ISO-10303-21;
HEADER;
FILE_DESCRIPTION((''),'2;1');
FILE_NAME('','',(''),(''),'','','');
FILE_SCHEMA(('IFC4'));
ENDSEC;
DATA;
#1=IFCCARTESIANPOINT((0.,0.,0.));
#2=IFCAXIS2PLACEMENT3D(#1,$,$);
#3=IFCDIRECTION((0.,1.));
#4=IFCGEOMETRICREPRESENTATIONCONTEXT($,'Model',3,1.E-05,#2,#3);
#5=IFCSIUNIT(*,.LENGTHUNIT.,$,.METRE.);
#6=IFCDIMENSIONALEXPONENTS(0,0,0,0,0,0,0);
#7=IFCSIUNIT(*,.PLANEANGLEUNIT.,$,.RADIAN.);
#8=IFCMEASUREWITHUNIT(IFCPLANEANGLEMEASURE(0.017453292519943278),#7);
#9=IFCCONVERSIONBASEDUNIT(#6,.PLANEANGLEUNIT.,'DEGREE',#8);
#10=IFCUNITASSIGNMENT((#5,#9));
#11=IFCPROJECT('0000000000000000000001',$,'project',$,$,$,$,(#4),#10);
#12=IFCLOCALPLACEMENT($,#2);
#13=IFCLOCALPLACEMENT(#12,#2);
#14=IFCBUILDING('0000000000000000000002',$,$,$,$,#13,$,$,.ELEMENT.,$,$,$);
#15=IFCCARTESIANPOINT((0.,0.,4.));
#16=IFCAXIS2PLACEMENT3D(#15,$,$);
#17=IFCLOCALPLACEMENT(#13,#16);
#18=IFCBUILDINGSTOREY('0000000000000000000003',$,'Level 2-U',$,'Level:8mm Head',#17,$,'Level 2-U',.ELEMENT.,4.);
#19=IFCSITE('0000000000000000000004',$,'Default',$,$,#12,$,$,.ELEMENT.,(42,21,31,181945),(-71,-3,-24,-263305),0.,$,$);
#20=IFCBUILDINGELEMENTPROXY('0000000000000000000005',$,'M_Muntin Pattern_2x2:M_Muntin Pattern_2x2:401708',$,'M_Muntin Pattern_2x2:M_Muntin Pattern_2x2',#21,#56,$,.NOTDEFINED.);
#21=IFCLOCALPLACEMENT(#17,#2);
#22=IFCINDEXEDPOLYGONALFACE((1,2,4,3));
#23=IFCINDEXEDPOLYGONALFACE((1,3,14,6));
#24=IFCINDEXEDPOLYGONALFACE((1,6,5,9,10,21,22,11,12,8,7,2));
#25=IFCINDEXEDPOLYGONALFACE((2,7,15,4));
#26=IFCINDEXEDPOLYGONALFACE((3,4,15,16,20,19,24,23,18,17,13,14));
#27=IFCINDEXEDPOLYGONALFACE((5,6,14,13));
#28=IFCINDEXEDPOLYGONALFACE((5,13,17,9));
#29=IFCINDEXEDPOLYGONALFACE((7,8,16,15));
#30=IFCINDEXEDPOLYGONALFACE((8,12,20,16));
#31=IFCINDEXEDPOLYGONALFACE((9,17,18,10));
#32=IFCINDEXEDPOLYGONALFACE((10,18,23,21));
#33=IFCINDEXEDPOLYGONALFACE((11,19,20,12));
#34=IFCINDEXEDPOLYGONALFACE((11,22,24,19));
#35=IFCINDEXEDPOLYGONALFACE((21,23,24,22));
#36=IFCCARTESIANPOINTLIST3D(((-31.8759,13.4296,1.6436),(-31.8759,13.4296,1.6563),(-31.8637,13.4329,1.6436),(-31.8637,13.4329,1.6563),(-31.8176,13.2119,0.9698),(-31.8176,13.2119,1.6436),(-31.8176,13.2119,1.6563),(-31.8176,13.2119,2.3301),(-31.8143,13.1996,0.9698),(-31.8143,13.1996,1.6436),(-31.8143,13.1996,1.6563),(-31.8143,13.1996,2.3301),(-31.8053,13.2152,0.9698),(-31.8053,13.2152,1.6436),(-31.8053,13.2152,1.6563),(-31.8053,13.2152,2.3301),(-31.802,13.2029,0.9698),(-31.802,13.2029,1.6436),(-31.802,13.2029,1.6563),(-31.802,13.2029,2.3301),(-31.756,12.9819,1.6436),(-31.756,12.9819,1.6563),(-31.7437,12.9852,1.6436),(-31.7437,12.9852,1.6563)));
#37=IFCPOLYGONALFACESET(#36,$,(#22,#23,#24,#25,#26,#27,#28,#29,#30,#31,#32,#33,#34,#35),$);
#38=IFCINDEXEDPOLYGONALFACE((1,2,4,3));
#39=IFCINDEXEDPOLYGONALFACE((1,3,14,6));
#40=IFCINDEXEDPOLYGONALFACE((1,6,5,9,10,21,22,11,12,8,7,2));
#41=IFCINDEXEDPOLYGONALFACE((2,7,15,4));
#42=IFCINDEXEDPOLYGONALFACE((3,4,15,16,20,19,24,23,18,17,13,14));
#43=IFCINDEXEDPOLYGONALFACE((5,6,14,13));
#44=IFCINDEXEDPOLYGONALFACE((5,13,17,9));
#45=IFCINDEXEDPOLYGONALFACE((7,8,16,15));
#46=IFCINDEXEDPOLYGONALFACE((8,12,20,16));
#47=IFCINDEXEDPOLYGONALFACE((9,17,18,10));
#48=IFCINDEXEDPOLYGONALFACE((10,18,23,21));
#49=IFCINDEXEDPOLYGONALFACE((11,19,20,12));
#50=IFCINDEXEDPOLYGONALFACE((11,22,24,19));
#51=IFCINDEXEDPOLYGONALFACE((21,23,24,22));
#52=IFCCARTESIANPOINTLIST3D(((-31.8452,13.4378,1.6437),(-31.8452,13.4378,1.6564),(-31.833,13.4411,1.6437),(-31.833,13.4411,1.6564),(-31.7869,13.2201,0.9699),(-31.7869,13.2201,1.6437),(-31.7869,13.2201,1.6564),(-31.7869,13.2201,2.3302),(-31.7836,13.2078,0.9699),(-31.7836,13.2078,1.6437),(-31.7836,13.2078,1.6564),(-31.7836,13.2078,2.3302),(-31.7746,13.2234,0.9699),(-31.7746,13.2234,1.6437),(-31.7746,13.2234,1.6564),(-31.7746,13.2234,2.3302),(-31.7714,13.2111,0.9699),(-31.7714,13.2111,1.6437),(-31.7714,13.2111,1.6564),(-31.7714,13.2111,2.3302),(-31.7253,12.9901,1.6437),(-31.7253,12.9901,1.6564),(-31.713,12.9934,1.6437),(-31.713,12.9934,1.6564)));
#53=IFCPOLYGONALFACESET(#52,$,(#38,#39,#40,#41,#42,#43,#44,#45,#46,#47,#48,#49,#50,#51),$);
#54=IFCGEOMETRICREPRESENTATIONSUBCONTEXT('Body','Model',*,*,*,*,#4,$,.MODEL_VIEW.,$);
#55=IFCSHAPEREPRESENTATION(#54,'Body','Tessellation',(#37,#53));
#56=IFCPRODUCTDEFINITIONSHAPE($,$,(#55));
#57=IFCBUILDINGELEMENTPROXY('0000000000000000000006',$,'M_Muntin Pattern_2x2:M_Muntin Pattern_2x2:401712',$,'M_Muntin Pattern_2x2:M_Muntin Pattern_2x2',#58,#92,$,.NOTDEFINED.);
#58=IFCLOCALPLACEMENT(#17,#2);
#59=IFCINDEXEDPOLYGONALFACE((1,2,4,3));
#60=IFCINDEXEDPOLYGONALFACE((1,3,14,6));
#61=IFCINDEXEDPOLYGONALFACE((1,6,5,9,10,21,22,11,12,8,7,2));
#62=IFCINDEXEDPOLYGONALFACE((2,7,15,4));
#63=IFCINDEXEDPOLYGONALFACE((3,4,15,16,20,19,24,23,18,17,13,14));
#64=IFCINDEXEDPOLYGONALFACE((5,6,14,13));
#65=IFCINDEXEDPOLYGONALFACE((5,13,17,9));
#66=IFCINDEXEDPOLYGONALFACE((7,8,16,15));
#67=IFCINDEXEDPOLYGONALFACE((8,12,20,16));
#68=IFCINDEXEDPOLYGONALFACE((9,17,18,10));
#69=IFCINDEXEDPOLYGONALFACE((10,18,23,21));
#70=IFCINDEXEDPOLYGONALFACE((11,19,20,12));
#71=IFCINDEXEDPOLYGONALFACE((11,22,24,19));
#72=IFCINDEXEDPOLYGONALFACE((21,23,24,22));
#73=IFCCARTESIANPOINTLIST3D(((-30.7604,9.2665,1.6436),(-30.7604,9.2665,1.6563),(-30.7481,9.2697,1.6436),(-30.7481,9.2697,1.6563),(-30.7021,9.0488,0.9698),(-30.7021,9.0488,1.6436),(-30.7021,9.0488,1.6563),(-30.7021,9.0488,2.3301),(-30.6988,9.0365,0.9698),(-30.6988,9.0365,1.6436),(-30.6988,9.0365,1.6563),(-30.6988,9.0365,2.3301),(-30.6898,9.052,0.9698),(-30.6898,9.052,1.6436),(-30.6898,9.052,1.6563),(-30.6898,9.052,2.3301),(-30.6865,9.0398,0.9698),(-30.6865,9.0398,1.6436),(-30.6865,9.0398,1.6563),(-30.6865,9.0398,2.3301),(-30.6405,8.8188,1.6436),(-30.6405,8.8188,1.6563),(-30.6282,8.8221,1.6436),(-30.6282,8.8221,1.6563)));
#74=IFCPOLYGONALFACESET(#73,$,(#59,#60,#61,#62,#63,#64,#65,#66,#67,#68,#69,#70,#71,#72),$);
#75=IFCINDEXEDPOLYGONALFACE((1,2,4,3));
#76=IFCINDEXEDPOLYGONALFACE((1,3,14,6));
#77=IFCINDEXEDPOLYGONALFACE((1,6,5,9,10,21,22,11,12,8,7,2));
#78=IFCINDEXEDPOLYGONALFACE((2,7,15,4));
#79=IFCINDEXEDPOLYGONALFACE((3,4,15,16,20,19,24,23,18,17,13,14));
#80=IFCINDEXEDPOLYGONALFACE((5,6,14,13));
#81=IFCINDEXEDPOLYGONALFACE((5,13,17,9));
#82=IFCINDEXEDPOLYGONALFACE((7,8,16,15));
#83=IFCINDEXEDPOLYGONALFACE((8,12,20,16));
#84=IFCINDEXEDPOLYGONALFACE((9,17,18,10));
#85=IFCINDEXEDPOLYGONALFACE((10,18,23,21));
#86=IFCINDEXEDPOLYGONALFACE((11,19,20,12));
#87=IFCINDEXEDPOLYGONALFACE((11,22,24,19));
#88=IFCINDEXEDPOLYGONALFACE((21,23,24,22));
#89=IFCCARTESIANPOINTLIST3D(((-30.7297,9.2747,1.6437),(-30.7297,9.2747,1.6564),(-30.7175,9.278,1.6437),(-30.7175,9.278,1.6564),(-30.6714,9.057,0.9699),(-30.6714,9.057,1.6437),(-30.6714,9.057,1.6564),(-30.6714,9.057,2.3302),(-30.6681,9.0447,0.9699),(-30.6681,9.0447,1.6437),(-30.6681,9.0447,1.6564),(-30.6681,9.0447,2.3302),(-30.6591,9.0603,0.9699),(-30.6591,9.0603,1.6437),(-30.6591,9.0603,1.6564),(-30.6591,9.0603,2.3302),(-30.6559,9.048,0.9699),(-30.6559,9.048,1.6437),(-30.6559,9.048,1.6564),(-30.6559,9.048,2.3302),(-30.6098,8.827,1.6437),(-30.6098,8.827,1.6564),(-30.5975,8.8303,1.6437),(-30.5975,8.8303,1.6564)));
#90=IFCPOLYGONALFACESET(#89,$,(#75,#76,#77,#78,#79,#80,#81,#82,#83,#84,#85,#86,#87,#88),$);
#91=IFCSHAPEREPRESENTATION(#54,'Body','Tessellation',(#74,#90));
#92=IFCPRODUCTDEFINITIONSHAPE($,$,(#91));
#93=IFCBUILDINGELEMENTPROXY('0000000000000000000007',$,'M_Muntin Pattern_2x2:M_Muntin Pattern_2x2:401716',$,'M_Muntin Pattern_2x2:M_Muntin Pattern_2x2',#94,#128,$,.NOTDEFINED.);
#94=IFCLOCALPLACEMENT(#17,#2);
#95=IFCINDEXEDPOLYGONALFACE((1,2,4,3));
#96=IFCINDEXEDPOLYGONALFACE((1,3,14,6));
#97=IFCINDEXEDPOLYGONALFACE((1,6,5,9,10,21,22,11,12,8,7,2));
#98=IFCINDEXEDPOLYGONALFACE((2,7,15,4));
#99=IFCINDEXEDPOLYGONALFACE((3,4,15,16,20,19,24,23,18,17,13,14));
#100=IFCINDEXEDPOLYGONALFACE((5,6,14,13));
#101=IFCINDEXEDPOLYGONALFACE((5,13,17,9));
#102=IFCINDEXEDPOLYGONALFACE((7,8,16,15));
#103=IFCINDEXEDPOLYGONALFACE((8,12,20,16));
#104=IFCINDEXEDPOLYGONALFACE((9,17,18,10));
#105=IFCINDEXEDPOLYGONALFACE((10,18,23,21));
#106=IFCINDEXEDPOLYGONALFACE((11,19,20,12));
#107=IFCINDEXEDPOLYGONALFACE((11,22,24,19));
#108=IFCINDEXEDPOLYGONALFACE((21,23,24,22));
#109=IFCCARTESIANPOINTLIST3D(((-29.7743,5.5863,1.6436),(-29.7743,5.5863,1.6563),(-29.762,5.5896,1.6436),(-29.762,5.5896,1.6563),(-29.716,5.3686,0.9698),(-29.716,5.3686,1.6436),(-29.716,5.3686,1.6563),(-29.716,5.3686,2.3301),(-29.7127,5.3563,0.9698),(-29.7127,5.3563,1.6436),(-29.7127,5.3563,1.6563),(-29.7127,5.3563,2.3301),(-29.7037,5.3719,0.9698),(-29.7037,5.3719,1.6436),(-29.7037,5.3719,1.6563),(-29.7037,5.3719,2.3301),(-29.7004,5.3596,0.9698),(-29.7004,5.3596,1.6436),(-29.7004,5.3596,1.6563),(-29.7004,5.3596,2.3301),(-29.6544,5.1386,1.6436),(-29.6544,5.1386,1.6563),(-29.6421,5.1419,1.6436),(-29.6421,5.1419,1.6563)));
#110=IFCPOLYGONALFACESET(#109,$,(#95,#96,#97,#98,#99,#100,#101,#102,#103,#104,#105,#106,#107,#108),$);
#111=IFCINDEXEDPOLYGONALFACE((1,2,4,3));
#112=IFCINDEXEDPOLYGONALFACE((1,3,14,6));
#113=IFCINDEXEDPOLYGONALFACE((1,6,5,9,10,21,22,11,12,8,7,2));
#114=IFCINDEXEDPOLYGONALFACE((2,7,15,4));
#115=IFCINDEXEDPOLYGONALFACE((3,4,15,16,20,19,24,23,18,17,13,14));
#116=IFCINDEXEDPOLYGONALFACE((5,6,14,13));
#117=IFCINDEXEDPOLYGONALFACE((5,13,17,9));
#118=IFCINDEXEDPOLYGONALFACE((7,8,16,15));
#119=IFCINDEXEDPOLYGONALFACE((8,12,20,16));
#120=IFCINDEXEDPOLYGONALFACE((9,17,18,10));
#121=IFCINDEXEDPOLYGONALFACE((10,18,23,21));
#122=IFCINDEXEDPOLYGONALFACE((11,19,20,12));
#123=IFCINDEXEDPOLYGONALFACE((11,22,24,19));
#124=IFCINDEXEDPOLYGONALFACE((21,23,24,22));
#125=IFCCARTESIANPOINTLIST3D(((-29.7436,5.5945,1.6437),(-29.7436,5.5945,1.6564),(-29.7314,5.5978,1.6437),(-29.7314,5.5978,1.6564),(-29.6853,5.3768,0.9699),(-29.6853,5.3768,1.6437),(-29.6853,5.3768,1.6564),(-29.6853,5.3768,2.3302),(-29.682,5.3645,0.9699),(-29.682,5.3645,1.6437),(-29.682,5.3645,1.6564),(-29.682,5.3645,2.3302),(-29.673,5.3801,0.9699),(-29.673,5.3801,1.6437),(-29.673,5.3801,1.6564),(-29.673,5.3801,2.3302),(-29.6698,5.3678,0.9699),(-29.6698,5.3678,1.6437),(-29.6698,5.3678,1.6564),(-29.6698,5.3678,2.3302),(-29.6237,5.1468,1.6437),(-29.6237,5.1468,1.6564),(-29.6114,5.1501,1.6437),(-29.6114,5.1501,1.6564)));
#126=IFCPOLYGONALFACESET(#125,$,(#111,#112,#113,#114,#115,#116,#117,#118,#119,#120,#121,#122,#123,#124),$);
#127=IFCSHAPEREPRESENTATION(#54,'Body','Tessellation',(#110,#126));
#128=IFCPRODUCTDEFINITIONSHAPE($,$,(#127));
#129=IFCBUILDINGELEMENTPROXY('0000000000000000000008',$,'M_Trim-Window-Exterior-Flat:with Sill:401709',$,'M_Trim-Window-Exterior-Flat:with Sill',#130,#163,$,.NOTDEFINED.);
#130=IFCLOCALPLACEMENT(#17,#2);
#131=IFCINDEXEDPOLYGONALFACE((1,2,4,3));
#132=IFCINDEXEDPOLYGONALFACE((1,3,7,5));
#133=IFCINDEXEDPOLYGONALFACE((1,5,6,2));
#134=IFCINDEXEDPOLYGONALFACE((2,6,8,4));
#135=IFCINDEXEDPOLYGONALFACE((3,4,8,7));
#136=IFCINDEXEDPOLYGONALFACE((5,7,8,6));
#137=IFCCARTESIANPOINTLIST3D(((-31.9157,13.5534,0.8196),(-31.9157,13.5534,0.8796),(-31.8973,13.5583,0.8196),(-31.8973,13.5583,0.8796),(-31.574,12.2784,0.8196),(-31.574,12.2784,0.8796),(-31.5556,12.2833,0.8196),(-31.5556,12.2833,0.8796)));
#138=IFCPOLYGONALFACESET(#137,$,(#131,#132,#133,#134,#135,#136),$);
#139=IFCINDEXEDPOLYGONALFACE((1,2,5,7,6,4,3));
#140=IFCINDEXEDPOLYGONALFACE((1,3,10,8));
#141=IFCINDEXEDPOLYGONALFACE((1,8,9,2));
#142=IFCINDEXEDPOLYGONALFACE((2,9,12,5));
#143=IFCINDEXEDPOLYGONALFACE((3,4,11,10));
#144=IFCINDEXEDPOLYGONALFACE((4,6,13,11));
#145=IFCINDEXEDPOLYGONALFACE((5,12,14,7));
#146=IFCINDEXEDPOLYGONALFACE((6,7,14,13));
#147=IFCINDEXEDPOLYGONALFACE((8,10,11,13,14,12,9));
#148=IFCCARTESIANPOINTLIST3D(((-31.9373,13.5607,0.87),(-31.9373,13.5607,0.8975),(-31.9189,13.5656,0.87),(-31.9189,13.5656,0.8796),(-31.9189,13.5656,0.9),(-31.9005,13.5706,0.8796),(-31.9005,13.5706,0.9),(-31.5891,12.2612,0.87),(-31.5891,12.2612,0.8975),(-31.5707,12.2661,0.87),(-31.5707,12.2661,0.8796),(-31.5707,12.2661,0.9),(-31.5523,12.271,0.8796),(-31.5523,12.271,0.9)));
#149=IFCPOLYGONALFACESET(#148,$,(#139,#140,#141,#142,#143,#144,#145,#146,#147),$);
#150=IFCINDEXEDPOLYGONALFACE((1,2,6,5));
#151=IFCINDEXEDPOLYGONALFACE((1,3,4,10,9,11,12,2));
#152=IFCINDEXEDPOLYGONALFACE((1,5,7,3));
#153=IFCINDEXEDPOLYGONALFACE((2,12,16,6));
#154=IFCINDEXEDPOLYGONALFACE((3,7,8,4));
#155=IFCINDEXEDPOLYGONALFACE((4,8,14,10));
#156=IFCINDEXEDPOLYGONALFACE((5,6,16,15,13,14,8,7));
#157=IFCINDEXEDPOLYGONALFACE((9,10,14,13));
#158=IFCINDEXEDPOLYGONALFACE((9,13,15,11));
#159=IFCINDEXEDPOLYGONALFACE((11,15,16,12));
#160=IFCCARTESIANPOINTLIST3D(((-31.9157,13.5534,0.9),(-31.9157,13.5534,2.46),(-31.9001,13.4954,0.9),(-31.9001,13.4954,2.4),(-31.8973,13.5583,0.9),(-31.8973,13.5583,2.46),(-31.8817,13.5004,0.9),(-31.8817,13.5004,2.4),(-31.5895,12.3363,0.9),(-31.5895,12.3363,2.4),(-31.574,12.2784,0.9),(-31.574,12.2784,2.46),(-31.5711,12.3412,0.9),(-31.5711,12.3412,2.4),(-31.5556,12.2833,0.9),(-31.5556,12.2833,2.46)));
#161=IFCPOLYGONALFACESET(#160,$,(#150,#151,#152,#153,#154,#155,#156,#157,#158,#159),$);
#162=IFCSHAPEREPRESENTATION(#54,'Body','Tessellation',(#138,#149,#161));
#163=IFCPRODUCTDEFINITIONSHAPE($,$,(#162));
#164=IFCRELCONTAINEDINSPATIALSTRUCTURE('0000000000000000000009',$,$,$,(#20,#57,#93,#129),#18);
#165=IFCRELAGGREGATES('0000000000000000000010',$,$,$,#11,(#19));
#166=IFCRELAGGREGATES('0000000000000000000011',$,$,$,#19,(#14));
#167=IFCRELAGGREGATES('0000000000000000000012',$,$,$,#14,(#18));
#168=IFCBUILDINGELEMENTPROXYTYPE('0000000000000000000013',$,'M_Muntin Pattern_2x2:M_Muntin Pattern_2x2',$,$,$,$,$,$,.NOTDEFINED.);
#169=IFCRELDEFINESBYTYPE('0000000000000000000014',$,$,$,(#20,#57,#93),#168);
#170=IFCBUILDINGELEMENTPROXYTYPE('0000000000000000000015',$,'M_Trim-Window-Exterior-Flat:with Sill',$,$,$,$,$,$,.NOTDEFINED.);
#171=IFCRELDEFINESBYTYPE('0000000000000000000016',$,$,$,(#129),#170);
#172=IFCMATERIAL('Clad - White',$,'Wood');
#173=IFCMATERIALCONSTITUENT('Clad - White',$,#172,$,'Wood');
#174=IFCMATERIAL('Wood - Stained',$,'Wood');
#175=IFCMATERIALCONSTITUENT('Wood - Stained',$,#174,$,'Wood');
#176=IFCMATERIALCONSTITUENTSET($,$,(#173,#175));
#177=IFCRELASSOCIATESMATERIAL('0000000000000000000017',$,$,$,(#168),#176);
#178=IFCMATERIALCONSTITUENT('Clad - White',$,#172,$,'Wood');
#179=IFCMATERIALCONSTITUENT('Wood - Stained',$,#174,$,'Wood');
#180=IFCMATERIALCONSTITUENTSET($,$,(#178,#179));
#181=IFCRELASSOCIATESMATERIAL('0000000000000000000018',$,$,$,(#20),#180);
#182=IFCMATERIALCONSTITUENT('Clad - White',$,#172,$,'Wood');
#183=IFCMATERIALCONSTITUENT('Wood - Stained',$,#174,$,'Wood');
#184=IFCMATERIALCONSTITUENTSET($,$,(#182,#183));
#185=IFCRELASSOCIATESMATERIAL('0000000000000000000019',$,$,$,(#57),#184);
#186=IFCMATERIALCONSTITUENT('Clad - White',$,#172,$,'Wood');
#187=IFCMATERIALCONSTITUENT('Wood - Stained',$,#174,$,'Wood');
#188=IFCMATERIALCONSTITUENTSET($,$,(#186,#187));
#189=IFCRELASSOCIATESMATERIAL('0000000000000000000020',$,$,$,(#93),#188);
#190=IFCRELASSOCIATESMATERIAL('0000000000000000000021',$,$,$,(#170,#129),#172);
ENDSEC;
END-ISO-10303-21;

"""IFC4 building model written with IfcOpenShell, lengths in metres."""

from ifc_helpers import new_model, entity, si_unit, converted_unit, direction, frame, origin, place, context, subcontext, project, spatial, indexed_curve, outline, extrude, source, transform, mapped, material, constituent, constituent_set, type_object, type_shapes, element, save


model = new_model("IFC4")

# Units and contexts
model_context = context("Model", 3, precision=1e-05, world=origin(), true_north=direction((0.0, 1.0)))
body_context = subcontext(model_context, "Body", "Model", "MODEL_VIEW")
ifc_project = project(units=[si_unit("LENGTHUNIT", "METRE"), converted_unit("PLANEANGLEUNIT", "DEGREE", entity("IfcPlaneAngleMeasure", 0.017453292519943278), si_unit("PLANEANGLEUNIT", "RADIAN"), dimensions=[0, 0, 0, 0, 0, 0, 0])], contexts=[model_context])

# Site, building, storey
site_placement = place(None, origin())
site = spatial("IfcSite", under=ifc_project, at=site_placement, Name="Default", CompositionType="ELEMENT", RefLatitude=(42, 21, 31, 181945), RefLongitude=(-71, -3, -24, -263305), RefElevation=0.0)
building_placement = place(site_placement, origin())
building = spatial("IfcBuilding", under=site, at=building_placement, CompositionType="ELEMENT")
storey_placement = place(building_placement, frame((0.0, 0.0, 4.0)))
storey = spatial("IfcBuildingStorey", under=building, at=storey_placement, Name="Level 2-U", ObjectType="Level:8mm Head", LongName="Level 2-U", CompositionType="ELEMENT", Elevation=4.0)

# Building element proxies
ifc_material_1 = material(Name="Clad - White", Category="Wood")
ifc_material_2 = material(Name="Wood - Stained", Category="Wood")
ifc_constituent_1 = constituent(ifc_material_1, Name="Clad - White", Category="Wood")
ifc_constituent_2 = constituent(ifc_material_2, Name="Wood - Stained", Category="Wood")
ifc_constituent_set_1 = constituent_set(constituents=[ifc_constituent_1, ifc_constituent_2])
ifc_constituent_3 = constituent(ifc_material_1, Name="Clad - White", Category="Wood")
ifc_constituent_4 = constituent(ifc_material_2, Name="Wood - Stained", Category="Wood")
ifc_constituent_set_2 = constituent_set(constituents=[ifc_constituent_3, ifc_constituent_4])
building_element_proxy_type_1 = type_object("IfcBuildingElementProxyType", Name="M_Muntin Pattern_2x2:M_Muntin Pattern_2x2", PredefinedType="NOTDEFINED", material=ifc_constituent_set_2)
shared_shape_1 = source(origin(), body_context, "Body", "SweptSolid", [
    extrude(outline(indexed_curve([(0.0064, -0.0064), (0.6801, -0.0064), (0.6801, 0.0063), (0.0064, 0.0063), (0.0064, 0.2317), (-0.0063, 0.2317), (-0.0063, 0.0063), (-0.6802, 0.0063), (-0.6802, -0.0064), (-0.0063, -0.0064), (-0.0063, -0.2317), (0.0064, -0.2317), (0.0064, -0.0064)], self_intersect=False)), frame((0.0, -0.0222, 0.6801), z_axis=(0.0, 1.0, 0.0), x_axis=(0.0, 0.0, 1.0)), (0.0, 0.0, 1.0), 0.0127),
    extrude(outline(indexed_curve([(0.0064, -0.0064), (0.6802, -0.0064), (0.6802, 0.0063), (0.0064, 0.0063), (0.0064, 0.2317), (-0.0063, 0.2317), (-0.0063, 0.0063), (-0.6802, 0.0063), (-0.6802, -0.0064), (-0.0063, -0.0064), (-0.0063, -0.2317), (0.0064, -0.2317), (0.0064, -0.0064)], self_intersect=False)), frame((0.0, 0.0095, 0.6802), z_axis=(0.0, 1.0, 0.0), x_axis=(0.0, 0.0, 1.0)), (0.0, 0.0, 1.0), 0.0127),
])
type_shapes(building_element_proxy_type_1, [shared_shape_1])
proxy_1_placement = place(storey_placement, frame((-31.7945, 13.2115, 0.9699), z_axis=(0.0, 0.0, 1.0), x_axis=(0.258819, -0.965926, 0.0)))
element("IfcBuildingElementProxy", 1, at=proxy_1_placement, inside=storey, type_object=building_element_proxy_type_1, material=ifc_constituent_set_1, Name="M_Muntin Pattern_2x2:M_Muntin Pattern_2x2:401708", ObjectType="M_Muntin Pattern_2x2:M_Muntin Pattern_2x2", PredefinedType="NOTDEFINED", context=body_context, shape_type="MappedRepresentation", body=[
    mapped(shared_shape_1, transform((0.0, 0.0, 0.0), scale=1.0)),
])
ifc_constituent_5 = constituent(ifc_material_1, Name="Clad - White", Category="Wood")
ifc_constituent_6 = constituent(ifc_material_2, Name="Wood - Stained", Category="Wood")
ifc_constituent_set_3 = constituent_set(constituents=[ifc_constituent_5, ifc_constituent_6])
proxy_2_placement = place(storey_placement, frame((-30.679, 9.0484, 0.9699), z_axis=(0.0, 0.0, 1.0), x_axis=(0.258819, -0.965926, 0.0)))
element("IfcBuildingElementProxy", 2, at=proxy_2_placement, inside=storey, type_object=building_element_proxy_type_1, material=ifc_constituent_set_3, Name="M_Muntin Pattern_2x2:M_Muntin Pattern_2x2:401712", ObjectType="M_Muntin Pattern_2x2:M_Muntin Pattern_2x2", PredefinedType="NOTDEFINED", context=body_context, shape_type="MappedRepresentation", body=[
    mapped(shared_shape_1, transform((0.0, 0.0, 0.0), scale=1.0)),
])
ifc_constituent_7 = constituent(ifc_material_1, Name="Clad - White", Category="Wood")
ifc_constituent_8 = constituent(ifc_material_2, Name="Wood - Stained", Category="Wood")
ifc_constituent_set_4 = constituent_set(constituents=[ifc_constituent_7, ifc_constituent_8])
proxy_3_placement = place(storey_placement, frame((-29.6929, 5.3682, 0.9699), z_axis=(0.0, 0.0, 1.0), x_axis=(0.258819, -0.965926, 0.0)))
element("IfcBuildingElementProxy", 3, at=proxy_3_placement, inside=storey, type_object=building_element_proxy_type_1, material=ifc_constituent_set_4, Name="M_Muntin Pattern_2x2:M_Muntin Pattern_2x2:401716", ObjectType="M_Muntin Pattern_2x2:M_Muntin Pattern_2x2", PredefinedType="NOTDEFINED", context=body_context, shape_type="MappedRepresentation", body=[
    mapped(shared_shape_1, transform((0.0, 0.0, 0.0), scale=1.0)),
])
building_element_proxy_type_2 = type_object("IfcBuildingElementProxyType", Name="M_Trim-Window-Exterior-Flat:with Sill", PredefinedType="NOTDEFINED", material=ifc_material_1)
shared_shape_2 = source(origin(), body_context, "Body", "SweptSolid", [
    extrude(outline(indexed_curve([(-0.66, -0.03), (0.66, -0.03), (0.66, 0.03), (-0.66, 0.03), (-0.66, -0.03)], self_intersect=False)), frame((0.0, -1.5504, 0.0), z_axis=(0.0, 0.0, 1.0), x_axis=(-1.0, 0.0, 0.0)), (0.0, 0.0, 1.0), 0.019),
    extrude(outline(indexed_curve([(-0.019, -0.0152), (0.0, -0.0152), (0.0, -0.0057), (0.019, -0.0057), (0.019, 0.0148), (0.0, 0.0148), (-0.019, 0.0123), (-0.019, -0.0152)], self_intersect=False)), frame((-0.6727, -1.5148, 0.019), z_axis=(1.0, 0.0, 0.0), x_axis=(0.0, 0.0, -1.0)), (0.0, 0.0, 1.0), 1.3454),
    extrude(outline(indexed_curve([(-0.795, -0.66), (0.765, -0.66), (0.765, -0.6), (-0.735, -0.6), (-0.735, 0.6), (0.765, 0.6), (0.765, 0.66), (-0.795, 0.66), (-0.795, -0.66)], self_intersect=False)), frame((0.0, -0.735, 0.0), z_axis=(0.0, 0.0, 1.0), x_axis=(0.0, -1.0, 0.0)), (0.0, 0.0, 1.0), 0.019),
])
type_shapes(building_element_proxy_type_2, [shared_shape_2])
for number, where, z_axis, x_axis, name in (
    (4, (-31.7264, 12.9208, 2.4), (-0.965926, -0.258819, 0.0), (0.258819, -0.965926, 0.0), "M_Trim-Window-Exterior-Flat:with Sill:401709"),
):
    element("IfcBuildingElementProxy", number, at=place(storey_placement, frame(where, z_axis=z_axis, x_axis=x_axis)), inside=storey, type_object=building_element_proxy_type_2, material=ifc_material_1, Name=name, ObjectType="M_Trim-Window-Exterior-Flat:with Sill", PredefinedType="NOTDEFINED", context=body_context, shape_type="MappedRepresentation", body=[
        mapped(shared_shape_2, transform((0.0, 0.0, 0.0), scale=1.0)),
    ])

save(model, "model.ifc")
